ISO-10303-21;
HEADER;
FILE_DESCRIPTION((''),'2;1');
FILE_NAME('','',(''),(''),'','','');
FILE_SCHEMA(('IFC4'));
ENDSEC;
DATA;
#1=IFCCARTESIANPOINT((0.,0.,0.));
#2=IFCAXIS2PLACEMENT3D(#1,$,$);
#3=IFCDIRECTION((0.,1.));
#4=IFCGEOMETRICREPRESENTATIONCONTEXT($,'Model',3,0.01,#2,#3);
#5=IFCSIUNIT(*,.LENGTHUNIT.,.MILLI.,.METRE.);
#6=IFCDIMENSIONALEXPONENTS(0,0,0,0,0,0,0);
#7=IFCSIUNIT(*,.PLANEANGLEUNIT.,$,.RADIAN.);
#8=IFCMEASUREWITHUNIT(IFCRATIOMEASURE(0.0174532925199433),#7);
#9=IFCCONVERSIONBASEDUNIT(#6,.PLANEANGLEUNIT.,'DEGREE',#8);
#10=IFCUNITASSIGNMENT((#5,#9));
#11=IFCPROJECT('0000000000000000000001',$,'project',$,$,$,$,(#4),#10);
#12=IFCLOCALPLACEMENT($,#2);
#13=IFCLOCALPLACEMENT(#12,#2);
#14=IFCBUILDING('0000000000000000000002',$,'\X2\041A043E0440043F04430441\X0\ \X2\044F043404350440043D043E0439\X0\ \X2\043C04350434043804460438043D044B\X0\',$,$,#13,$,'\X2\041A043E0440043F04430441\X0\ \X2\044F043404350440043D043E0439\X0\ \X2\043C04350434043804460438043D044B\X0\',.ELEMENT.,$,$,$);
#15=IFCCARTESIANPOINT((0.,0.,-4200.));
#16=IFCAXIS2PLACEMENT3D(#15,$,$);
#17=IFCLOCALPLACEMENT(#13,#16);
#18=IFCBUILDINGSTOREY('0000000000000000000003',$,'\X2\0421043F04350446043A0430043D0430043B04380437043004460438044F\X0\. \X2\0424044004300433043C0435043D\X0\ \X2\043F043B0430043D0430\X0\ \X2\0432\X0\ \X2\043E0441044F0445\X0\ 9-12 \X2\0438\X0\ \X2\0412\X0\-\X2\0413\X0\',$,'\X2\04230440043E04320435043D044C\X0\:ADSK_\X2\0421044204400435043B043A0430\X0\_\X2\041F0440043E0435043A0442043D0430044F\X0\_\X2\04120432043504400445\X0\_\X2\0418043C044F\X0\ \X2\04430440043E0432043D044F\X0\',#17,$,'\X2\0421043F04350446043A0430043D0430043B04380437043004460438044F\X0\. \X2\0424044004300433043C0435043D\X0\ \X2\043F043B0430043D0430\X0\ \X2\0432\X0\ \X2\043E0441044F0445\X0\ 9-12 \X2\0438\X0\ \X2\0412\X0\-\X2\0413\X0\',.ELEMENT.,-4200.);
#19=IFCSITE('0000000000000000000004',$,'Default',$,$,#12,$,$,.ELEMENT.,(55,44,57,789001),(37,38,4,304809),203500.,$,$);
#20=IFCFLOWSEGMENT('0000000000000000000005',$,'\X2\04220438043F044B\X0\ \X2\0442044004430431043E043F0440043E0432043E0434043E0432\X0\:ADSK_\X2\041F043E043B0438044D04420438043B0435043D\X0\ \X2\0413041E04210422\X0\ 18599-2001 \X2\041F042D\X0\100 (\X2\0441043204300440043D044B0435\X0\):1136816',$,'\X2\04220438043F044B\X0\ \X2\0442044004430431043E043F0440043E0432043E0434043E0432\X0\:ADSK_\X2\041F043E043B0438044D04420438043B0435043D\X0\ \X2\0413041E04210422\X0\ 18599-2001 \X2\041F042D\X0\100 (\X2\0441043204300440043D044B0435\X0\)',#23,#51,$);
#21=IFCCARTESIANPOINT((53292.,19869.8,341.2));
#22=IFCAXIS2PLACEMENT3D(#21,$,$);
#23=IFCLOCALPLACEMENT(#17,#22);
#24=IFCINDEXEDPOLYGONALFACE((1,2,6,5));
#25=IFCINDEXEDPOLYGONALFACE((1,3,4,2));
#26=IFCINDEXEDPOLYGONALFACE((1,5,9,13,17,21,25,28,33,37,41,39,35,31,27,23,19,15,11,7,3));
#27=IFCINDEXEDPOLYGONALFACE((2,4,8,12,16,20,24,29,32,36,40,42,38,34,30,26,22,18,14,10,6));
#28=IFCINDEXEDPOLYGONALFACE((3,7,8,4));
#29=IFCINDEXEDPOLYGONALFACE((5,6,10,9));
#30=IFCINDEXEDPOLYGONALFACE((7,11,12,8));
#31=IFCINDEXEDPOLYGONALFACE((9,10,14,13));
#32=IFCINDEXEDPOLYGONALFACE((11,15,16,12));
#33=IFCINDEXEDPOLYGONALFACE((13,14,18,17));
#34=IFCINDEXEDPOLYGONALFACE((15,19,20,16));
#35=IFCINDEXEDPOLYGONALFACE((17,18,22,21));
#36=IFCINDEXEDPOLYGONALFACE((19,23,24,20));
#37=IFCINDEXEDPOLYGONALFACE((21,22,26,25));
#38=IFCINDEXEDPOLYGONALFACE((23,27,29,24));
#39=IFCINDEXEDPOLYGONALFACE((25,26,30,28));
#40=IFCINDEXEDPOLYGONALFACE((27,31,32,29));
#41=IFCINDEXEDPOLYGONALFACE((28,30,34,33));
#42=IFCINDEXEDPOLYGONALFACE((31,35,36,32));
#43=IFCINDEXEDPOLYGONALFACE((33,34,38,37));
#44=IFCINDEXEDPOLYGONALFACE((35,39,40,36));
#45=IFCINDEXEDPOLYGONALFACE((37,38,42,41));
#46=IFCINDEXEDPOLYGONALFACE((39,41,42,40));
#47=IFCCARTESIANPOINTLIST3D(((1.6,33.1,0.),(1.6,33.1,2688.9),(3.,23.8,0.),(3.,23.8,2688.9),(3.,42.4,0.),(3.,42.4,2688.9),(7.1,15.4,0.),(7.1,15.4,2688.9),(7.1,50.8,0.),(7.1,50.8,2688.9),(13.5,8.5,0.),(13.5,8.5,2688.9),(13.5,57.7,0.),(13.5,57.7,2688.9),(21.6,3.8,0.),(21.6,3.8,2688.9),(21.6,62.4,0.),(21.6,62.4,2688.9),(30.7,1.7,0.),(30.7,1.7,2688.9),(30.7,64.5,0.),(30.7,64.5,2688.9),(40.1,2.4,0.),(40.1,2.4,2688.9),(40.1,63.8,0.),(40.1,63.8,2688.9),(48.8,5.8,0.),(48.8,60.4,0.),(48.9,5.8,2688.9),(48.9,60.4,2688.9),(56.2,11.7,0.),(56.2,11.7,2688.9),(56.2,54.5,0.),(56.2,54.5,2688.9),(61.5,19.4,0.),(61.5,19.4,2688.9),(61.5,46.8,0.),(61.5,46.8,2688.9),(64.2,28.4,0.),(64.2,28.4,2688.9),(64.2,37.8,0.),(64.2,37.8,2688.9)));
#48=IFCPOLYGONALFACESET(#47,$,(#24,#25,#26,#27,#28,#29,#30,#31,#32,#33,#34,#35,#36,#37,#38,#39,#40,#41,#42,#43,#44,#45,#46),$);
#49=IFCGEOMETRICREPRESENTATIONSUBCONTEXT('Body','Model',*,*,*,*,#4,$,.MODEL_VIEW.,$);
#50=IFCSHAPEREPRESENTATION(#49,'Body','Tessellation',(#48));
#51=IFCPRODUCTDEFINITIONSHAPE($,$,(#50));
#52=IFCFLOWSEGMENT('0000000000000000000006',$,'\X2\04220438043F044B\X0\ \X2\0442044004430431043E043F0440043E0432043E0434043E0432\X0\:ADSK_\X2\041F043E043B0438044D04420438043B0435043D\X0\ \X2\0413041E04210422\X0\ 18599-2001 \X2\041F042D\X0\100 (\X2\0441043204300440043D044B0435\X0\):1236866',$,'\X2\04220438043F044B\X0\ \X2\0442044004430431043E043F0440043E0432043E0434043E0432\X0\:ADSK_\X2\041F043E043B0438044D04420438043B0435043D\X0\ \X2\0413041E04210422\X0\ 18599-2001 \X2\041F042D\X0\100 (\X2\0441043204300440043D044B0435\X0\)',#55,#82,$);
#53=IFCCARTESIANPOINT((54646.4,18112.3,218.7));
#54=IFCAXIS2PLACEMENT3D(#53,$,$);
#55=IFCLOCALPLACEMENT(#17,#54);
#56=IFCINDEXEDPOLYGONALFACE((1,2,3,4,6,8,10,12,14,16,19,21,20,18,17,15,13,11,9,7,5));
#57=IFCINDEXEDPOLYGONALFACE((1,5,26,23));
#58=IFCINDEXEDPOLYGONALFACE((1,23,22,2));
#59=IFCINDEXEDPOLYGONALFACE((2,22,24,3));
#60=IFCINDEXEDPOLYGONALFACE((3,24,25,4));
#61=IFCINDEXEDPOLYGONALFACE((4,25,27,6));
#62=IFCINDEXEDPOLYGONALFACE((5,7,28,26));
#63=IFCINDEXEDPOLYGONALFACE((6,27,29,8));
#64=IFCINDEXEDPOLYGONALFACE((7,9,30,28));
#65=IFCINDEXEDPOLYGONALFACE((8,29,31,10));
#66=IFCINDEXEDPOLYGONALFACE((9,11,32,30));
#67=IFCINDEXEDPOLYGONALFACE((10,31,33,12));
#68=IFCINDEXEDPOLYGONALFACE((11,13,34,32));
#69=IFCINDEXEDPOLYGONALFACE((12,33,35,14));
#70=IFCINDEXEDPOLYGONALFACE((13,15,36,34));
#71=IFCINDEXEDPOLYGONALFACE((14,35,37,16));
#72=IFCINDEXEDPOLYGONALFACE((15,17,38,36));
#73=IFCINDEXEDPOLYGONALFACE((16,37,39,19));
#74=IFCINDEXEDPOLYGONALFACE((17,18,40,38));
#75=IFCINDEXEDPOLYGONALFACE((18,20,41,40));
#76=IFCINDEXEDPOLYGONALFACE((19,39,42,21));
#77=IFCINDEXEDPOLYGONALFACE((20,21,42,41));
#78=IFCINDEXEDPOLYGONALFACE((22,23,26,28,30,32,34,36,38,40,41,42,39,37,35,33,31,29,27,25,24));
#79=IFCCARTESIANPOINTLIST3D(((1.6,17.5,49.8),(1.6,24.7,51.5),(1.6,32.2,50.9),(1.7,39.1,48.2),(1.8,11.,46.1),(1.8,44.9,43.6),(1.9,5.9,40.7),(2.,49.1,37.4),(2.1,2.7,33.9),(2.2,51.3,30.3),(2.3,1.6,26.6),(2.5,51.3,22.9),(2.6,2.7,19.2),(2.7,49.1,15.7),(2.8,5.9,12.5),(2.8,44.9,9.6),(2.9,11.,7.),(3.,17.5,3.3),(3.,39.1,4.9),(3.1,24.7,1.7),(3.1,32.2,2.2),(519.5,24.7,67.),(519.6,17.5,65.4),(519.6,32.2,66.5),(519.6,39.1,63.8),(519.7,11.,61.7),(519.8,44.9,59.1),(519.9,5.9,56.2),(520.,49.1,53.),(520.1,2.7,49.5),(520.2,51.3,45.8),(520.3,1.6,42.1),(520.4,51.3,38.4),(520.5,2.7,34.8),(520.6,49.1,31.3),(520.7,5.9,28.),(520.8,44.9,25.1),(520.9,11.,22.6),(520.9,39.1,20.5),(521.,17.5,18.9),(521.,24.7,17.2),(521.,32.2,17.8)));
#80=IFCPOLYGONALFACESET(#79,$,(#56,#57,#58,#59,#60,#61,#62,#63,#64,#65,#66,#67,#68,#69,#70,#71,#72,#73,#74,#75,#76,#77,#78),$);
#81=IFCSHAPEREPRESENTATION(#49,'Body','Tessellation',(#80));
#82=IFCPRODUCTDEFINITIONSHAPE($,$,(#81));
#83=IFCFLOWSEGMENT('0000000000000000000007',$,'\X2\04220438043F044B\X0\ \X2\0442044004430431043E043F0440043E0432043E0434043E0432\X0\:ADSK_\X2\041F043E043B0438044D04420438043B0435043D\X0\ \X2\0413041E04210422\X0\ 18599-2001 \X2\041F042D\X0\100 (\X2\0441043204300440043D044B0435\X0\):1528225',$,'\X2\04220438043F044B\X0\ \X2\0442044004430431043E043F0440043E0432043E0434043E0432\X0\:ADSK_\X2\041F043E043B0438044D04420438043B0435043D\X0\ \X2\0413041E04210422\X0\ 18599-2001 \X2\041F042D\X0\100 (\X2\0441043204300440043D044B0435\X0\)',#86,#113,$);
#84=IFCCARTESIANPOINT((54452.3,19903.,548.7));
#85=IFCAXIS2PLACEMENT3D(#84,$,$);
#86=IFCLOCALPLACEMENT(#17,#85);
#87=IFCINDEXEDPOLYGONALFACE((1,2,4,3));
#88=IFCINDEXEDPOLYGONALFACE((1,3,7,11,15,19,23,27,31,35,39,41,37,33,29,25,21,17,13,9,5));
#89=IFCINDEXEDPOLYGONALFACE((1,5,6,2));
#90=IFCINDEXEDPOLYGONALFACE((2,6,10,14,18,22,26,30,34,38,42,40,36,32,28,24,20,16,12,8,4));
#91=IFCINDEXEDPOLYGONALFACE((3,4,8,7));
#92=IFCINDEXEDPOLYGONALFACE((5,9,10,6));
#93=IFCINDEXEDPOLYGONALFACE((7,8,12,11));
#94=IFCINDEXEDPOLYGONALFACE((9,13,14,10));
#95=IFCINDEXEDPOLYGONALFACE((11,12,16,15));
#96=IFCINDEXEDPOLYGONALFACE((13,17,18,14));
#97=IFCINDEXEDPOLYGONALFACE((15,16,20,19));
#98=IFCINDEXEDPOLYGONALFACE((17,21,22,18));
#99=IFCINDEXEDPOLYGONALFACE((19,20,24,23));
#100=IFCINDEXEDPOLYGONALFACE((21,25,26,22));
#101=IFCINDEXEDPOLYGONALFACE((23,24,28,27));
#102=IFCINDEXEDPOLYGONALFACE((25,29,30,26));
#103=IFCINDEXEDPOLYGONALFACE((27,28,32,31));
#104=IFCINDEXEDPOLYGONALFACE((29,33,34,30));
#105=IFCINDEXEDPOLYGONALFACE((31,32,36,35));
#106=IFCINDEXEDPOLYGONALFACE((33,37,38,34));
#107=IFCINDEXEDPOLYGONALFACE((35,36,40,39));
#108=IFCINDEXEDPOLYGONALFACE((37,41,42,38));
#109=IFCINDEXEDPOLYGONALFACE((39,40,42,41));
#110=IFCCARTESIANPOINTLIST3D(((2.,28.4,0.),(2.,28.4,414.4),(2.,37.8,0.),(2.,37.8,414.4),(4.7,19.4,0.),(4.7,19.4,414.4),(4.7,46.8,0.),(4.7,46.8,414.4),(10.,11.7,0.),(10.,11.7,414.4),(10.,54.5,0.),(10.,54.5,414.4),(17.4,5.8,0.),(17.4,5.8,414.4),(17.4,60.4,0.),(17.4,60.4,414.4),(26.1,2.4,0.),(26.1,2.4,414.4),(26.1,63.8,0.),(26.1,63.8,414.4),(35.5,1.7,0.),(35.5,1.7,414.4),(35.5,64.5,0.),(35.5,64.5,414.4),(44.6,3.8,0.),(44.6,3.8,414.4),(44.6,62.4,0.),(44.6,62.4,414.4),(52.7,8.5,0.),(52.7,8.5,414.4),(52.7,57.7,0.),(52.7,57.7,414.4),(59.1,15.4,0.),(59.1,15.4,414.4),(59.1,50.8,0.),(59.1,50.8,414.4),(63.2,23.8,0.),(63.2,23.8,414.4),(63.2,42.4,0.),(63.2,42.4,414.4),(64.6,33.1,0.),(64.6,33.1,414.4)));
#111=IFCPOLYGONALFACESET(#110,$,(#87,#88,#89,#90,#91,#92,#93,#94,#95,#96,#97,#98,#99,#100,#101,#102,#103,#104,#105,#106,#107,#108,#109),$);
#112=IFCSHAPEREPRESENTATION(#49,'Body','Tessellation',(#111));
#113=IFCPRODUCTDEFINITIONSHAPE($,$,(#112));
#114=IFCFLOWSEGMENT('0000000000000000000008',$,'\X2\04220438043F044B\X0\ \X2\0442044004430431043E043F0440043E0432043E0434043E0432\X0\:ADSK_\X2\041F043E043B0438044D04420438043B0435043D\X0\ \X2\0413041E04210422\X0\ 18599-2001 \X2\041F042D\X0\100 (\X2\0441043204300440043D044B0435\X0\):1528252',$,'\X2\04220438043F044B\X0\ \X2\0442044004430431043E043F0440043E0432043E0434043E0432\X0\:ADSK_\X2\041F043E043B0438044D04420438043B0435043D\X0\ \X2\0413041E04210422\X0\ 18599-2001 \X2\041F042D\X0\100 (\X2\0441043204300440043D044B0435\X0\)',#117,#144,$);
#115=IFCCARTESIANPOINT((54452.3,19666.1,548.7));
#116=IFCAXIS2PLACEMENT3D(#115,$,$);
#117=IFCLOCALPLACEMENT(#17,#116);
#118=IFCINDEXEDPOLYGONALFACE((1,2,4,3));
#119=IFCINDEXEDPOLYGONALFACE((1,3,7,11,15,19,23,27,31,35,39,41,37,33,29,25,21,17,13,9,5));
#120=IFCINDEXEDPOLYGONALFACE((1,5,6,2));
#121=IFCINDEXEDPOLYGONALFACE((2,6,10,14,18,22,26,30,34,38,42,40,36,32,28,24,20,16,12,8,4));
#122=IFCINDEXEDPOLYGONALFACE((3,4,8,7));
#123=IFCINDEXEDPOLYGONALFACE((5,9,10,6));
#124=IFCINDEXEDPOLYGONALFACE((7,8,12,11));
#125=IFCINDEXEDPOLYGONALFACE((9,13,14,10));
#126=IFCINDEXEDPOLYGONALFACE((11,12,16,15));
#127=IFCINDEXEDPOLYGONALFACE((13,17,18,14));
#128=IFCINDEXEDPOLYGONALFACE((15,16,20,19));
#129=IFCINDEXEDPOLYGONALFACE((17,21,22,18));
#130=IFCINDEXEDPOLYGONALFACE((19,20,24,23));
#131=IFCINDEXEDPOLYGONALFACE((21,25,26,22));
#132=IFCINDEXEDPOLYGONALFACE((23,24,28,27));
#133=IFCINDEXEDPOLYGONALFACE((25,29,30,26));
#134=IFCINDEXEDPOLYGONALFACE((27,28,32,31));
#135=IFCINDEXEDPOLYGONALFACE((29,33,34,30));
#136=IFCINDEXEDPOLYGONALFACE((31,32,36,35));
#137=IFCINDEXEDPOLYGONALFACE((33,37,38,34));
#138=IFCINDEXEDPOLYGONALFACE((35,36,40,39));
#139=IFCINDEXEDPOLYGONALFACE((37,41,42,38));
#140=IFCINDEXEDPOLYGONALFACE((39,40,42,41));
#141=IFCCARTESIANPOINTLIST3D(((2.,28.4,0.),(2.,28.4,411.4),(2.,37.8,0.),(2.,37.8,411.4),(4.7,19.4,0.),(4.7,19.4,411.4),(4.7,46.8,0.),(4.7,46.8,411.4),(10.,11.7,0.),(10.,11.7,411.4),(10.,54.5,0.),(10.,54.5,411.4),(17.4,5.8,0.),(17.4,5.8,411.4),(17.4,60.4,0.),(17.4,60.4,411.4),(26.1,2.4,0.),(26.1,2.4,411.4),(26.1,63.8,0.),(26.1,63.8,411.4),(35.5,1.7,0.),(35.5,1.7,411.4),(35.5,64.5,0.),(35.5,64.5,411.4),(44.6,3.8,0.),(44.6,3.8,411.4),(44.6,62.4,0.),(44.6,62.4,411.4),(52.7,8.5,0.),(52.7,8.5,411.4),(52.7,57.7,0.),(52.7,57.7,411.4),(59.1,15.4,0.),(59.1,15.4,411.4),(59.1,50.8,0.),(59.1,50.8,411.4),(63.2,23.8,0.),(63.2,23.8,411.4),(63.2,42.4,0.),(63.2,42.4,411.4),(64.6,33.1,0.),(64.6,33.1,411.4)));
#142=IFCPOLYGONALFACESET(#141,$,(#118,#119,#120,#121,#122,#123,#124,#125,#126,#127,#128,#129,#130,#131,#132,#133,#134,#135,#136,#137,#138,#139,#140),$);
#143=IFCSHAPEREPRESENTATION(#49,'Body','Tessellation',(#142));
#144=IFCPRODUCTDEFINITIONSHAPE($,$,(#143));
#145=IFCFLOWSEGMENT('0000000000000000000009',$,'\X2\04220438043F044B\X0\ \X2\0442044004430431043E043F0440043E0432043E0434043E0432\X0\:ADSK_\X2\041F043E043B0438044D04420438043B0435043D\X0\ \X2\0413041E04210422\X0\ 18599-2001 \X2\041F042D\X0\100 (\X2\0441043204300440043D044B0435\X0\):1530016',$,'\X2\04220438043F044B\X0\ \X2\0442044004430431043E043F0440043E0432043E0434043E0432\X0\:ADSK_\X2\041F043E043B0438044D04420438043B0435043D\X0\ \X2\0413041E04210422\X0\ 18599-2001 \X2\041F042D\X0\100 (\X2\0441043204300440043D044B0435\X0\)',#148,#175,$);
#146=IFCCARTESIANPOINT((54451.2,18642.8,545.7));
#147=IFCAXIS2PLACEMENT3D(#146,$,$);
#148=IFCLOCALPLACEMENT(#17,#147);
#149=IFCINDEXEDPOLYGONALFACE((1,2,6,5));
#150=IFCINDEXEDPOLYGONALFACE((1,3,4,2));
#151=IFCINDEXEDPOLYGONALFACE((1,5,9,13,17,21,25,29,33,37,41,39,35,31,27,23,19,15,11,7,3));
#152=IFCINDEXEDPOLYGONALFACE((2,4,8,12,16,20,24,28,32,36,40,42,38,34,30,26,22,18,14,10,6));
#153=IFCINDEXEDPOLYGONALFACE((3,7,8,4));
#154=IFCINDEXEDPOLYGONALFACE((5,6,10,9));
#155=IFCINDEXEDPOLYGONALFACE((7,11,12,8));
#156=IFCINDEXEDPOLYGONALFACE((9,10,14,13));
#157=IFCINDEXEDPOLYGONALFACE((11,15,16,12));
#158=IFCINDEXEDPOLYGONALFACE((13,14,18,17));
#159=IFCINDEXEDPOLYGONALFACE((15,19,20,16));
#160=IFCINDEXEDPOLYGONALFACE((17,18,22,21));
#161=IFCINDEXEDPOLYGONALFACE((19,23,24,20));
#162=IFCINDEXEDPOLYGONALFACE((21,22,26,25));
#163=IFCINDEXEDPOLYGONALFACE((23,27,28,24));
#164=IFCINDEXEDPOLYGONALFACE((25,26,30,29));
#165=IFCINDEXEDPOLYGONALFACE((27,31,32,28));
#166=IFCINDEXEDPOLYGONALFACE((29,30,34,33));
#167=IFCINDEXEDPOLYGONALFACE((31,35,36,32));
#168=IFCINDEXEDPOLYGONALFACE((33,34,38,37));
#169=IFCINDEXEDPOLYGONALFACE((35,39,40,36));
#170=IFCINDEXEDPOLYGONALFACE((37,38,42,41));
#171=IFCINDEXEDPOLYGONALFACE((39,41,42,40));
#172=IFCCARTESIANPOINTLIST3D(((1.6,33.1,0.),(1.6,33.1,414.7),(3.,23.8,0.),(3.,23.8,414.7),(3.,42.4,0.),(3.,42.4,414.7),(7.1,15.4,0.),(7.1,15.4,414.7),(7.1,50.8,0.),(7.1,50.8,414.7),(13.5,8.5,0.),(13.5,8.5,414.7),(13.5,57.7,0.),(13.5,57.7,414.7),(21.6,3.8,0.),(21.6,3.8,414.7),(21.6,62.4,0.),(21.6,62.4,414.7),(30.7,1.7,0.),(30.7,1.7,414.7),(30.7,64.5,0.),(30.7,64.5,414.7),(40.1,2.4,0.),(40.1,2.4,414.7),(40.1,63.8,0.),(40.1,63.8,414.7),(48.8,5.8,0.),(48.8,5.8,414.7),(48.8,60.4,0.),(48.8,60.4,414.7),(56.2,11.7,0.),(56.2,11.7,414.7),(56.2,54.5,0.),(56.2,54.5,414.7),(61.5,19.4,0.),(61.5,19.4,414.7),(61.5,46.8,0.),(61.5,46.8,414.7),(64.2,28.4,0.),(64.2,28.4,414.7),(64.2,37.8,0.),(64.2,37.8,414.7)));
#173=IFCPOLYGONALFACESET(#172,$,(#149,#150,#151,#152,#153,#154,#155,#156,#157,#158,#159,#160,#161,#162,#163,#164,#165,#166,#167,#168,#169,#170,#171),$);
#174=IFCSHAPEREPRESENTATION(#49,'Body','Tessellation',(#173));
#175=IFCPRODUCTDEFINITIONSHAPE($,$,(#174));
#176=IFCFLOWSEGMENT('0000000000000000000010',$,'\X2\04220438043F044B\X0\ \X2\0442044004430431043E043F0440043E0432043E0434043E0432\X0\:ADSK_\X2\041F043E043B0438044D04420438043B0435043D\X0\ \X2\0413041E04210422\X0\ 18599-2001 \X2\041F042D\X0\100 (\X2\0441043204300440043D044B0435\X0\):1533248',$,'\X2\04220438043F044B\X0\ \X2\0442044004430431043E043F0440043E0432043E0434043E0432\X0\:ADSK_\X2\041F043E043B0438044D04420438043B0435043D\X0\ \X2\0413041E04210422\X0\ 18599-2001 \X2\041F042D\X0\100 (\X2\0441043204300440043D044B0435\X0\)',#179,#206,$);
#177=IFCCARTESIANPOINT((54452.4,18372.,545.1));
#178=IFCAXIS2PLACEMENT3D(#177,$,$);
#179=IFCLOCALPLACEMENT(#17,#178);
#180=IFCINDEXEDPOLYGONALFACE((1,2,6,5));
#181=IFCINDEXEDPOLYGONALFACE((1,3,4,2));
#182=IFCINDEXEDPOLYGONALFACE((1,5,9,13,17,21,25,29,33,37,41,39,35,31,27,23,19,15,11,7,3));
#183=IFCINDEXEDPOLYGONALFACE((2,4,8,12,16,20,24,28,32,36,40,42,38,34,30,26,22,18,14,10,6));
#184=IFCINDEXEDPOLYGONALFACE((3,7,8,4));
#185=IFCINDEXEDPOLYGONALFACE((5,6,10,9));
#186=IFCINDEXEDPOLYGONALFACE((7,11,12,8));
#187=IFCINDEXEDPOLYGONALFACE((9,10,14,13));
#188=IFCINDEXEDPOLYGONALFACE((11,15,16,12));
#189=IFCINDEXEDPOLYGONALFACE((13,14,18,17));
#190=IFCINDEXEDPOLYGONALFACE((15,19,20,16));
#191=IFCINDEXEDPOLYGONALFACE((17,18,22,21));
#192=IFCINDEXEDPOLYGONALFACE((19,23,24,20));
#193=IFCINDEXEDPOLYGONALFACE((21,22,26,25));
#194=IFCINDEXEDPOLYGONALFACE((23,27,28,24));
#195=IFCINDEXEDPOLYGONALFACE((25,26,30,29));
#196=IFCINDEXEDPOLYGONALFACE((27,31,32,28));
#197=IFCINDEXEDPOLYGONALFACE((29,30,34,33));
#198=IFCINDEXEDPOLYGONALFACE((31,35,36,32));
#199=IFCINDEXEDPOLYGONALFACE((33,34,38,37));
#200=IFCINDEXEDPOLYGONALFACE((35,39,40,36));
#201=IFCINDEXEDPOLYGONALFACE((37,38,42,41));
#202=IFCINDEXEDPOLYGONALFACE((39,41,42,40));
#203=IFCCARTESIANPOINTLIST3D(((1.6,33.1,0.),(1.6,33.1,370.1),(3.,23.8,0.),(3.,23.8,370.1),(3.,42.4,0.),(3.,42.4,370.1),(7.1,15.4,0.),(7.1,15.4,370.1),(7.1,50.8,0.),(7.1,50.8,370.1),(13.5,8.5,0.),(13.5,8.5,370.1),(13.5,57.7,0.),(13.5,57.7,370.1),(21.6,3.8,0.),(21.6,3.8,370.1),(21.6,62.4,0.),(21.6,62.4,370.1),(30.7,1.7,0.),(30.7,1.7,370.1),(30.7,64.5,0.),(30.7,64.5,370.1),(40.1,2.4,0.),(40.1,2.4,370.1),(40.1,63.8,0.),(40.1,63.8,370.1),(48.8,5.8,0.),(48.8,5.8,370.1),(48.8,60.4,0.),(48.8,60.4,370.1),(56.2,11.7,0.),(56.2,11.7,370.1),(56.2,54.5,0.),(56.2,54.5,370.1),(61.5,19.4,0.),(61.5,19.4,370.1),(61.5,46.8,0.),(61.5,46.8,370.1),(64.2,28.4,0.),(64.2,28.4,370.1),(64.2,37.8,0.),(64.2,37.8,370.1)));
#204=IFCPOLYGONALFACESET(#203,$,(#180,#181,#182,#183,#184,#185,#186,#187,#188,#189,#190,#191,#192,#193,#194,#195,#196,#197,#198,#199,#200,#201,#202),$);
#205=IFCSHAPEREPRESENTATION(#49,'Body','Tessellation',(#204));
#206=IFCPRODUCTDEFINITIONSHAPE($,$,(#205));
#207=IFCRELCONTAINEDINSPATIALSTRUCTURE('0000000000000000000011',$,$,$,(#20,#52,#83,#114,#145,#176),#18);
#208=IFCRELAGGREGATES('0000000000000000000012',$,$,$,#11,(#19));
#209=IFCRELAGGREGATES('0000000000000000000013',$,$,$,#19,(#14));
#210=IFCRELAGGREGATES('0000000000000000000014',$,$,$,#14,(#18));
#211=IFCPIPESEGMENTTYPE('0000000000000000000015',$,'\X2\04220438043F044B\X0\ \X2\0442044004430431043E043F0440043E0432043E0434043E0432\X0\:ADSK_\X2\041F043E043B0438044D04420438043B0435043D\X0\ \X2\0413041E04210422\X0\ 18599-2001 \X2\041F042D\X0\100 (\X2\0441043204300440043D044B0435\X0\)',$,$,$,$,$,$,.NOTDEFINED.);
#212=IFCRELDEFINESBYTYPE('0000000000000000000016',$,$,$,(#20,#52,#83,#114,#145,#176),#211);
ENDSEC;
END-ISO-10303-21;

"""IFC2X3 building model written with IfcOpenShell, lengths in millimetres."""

from ifc_helpers import new_model, entity, si_unit, converted_unit, direction, frame, origin, origin_2d_with_axis, place, context, subcontext, project, spatial, circle, extrude, type_object, element, save


model = new_model("IFC2X3")

# Units and contexts
model_context = context("Model", 3, precision=0.01, world=origin(), true_north=direction((0.0, 1.0)))
body_context = subcontext(model_context, "Body", "Model", "MODEL_VIEW")
ifc_project = project(units=[si_unit("LENGTHUNIT", "METRE", prefix="MILLI"), converted_unit("PLANEANGLEUNIT", "DEGREE", entity("IfcRatioMeasure", 0.0174532925199433), si_unit("PLANEANGLEUNIT", "RADIAN"), dimensions=[0, 0, 0, 0, 0, 0, 0])], contexts=[model_context])

# Site, building, storey
site_placement = place(None, origin())
site = spatial("IfcSite", under=ifc_project, at=site_placement, Name="Default", CompositionType="ELEMENT", RefLatitude=(55, 44, 57, 789001), RefLongitude=(37, 38, 4, 304809), RefElevation=203500.0)
building_placement = place(site_placement, origin())
building = spatial("IfcBuilding", under=site, at=building_placement, Name="Корпус ядерной медицины", LongName="Корпус ядерной медицины", CompositionType="ELEMENT")
storey_placement = place(building_placement, frame((0.0, 0.0, -4200.0)))
storey = spatial("IfcBuildingStorey", under=building, at=storey_placement, Name="Спецканализация. Фрагмен плана в осях 9-12 и В-Г", ObjectType="Уровень:ADSK_Стрелка_Проектная_Вверх_Имя уровня", LongName="Спецканализация. Фрагмен плана в осях 9-12 и В-Г", CompositionType="ELEMENT", Elevation=-4200.0)

# Flow segments
pipe_segment_type = type_object("IfcPipeSegmentType", Name="Типы трубопроводов:ADSK_Полиэтилен ГОСТ 18599-2001 ПЭ100 (сварные)", PredefinedType="NOTDEFINED")
flow_segment_1_placement = place(storey_placement, frame((53292.0, 19869.8, 341.2)))
element("IfcFlowSegment", 1, at=flow_segment_1_placement, inside=storey, type_object=pipe_segment_type, Name="Типы трубопроводов:ADSK_Полиэтилен ГОСТ 18599-2001 ПЭ100 (сварные):1136816", ObjectType="Типы трубопроводов:ADSK_Полиэтилен ГОСТ 18599-2001 ПЭ100 (сварные)", context=body_context, shape_type="SweptSolid", body=[
    extrude(circle(Radius=31.5, at=origin_2d_with_axis()), frame((33.1, 33.1, 0.0), z_axis=(0.0, 0.0, 1.0), x_axis=(-1.0, 0.0, 0.0)), (0.0, 0.0, 1.0), 2688.9),
])
flow_segment_2_placement = place(storey_placement, frame((54646.4, 18112.3, 218.7)))
element("IfcFlowSegment", 2, at=flow_segment_2_placement, inside=storey, type_object=pipe_segment_type, Name="Типы трубопроводов:ADSK_Полиэтилен ГОСТ 18599-2001 ПЭ100 (сварные):1236866", ObjectType="Типы трубопроводов:ADSK_Полиэтилен ГОСТ 18599-2001 ПЭ100 (сварные)", context=body_context, shape_type="SweptSolid", body=[
    extrude(circle(Radius=25.0, at=origin_2d_with_axis()), frame((2.3, 26.6, 26.6), z_axis=(0.99955, 0.0, 0.029987), x_axis=(0.0, -1.0, 0.0)), (0.0, 0.0, 1.0), 518.2),
])
flow_segment_3_placement = place(storey_placement, frame((54452.3, 19903.0, 548.7)))
element("IfcFlowSegment", 3, at=flow_segment_3_placement, inside=storey, type_object=pipe_segment_type, Name="Типы трубопроводов:ADSK_Полиэтилен ГОСТ 18599-2001 ПЭ100 (сварные):1528225", ObjectType="Типы трубопроводов:ADSK_Полиэтилен ГОСТ 18599-2001 ПЭ100 (сварные)", context=body_context, shape_type="SweptSolid", body=[
    extrude(circle(Radius=31.5, at=origin_2d_with_axis()), frame((33.1, 33.1, 0.0)), (0.0, 0.0, 1.0), 414.4),
])
flow_segment_4_placement = place(storey_placement, frame((54452.3, 19666.1, 548.7)))
element("IfcFlowSegment", 4, at=flow_segment_4_placement, inside=storey, type_object=pipe_segment_type, Name="Типы трубопроводов:ADSK_Полиэтилен ГОСТ 18599-2001 ПЭ100 (сварные):1528252", ObjectType="Типы трубопроводов:ADSK_Полиэтилен ГОСТ 18599-2001 ПЭ100 (сварные)", context=body_context, shape_type="SweptSolid", body=[
    extrude(circle(Radius=31.5, at=origin_2d_with_axis()), frame((33.1, 33.1, 0.0)), (0.0, 0.0, 1.0), 411.4),
])
flow_segment_5_placement = place(storey_placement, frame((54451.2, 18642.8, 545.7)))
element("IfcFlowSegment", 5, at=flow_segment_5_placement, inside=storey, type_object=pipe_segment_type, Name="Типы трубопроводов:ADSK_Полиэтилен ГОСТ 18599-2001 ПЭ100 (сварные):1530016", ObjectType="Типы трубопроводов:ADSK_Полиэтилен ГОСТ 18599-2001 ПЭ100 (сварные)", context=body_context, shape_type="SweptSolid", body=[
    extrude(circle(Radius=31.5, at=origin_2d_with_axis()), frame((33.1, 33.1, 0.0), z_axis=(0.0, 0.0, 1.0), x_axis=(-1.0, 0.0, 0.0)), (0.0, 0.0, 1.0), 414.7),
])
flow_segment_6_placement = place(storey_placement, frame((54452.4, 18372.0, 545.1)))
element("IfcFlowSegment", 6, at=flow_segment_6_placement, inside=storey, type_object=pipe_segment_type, Name="Типы трубопроводов:ADSK_Полиэтилен ГОСТ 18599-2001 ПЭ100 (сварные):1533248", ObjectType="Типы трубопроводов:ADSK_Полиэтилен ГОСТ 18599-2001 ПЭ100 (сварные)", context=body_context, shape_type="SweptSolid", body=[
    extrude(circle(Radius=31.5, at=origin_2d_with_axis()), frame((33.1, 33.1, 0.0), z_axis=(0.0, 0.0, 1.0), x_axis=(-1.0, 0.0, 0.0)), (0.0, 0.0, 1.0), 370.1),
])

save(model, "model.ifc")
